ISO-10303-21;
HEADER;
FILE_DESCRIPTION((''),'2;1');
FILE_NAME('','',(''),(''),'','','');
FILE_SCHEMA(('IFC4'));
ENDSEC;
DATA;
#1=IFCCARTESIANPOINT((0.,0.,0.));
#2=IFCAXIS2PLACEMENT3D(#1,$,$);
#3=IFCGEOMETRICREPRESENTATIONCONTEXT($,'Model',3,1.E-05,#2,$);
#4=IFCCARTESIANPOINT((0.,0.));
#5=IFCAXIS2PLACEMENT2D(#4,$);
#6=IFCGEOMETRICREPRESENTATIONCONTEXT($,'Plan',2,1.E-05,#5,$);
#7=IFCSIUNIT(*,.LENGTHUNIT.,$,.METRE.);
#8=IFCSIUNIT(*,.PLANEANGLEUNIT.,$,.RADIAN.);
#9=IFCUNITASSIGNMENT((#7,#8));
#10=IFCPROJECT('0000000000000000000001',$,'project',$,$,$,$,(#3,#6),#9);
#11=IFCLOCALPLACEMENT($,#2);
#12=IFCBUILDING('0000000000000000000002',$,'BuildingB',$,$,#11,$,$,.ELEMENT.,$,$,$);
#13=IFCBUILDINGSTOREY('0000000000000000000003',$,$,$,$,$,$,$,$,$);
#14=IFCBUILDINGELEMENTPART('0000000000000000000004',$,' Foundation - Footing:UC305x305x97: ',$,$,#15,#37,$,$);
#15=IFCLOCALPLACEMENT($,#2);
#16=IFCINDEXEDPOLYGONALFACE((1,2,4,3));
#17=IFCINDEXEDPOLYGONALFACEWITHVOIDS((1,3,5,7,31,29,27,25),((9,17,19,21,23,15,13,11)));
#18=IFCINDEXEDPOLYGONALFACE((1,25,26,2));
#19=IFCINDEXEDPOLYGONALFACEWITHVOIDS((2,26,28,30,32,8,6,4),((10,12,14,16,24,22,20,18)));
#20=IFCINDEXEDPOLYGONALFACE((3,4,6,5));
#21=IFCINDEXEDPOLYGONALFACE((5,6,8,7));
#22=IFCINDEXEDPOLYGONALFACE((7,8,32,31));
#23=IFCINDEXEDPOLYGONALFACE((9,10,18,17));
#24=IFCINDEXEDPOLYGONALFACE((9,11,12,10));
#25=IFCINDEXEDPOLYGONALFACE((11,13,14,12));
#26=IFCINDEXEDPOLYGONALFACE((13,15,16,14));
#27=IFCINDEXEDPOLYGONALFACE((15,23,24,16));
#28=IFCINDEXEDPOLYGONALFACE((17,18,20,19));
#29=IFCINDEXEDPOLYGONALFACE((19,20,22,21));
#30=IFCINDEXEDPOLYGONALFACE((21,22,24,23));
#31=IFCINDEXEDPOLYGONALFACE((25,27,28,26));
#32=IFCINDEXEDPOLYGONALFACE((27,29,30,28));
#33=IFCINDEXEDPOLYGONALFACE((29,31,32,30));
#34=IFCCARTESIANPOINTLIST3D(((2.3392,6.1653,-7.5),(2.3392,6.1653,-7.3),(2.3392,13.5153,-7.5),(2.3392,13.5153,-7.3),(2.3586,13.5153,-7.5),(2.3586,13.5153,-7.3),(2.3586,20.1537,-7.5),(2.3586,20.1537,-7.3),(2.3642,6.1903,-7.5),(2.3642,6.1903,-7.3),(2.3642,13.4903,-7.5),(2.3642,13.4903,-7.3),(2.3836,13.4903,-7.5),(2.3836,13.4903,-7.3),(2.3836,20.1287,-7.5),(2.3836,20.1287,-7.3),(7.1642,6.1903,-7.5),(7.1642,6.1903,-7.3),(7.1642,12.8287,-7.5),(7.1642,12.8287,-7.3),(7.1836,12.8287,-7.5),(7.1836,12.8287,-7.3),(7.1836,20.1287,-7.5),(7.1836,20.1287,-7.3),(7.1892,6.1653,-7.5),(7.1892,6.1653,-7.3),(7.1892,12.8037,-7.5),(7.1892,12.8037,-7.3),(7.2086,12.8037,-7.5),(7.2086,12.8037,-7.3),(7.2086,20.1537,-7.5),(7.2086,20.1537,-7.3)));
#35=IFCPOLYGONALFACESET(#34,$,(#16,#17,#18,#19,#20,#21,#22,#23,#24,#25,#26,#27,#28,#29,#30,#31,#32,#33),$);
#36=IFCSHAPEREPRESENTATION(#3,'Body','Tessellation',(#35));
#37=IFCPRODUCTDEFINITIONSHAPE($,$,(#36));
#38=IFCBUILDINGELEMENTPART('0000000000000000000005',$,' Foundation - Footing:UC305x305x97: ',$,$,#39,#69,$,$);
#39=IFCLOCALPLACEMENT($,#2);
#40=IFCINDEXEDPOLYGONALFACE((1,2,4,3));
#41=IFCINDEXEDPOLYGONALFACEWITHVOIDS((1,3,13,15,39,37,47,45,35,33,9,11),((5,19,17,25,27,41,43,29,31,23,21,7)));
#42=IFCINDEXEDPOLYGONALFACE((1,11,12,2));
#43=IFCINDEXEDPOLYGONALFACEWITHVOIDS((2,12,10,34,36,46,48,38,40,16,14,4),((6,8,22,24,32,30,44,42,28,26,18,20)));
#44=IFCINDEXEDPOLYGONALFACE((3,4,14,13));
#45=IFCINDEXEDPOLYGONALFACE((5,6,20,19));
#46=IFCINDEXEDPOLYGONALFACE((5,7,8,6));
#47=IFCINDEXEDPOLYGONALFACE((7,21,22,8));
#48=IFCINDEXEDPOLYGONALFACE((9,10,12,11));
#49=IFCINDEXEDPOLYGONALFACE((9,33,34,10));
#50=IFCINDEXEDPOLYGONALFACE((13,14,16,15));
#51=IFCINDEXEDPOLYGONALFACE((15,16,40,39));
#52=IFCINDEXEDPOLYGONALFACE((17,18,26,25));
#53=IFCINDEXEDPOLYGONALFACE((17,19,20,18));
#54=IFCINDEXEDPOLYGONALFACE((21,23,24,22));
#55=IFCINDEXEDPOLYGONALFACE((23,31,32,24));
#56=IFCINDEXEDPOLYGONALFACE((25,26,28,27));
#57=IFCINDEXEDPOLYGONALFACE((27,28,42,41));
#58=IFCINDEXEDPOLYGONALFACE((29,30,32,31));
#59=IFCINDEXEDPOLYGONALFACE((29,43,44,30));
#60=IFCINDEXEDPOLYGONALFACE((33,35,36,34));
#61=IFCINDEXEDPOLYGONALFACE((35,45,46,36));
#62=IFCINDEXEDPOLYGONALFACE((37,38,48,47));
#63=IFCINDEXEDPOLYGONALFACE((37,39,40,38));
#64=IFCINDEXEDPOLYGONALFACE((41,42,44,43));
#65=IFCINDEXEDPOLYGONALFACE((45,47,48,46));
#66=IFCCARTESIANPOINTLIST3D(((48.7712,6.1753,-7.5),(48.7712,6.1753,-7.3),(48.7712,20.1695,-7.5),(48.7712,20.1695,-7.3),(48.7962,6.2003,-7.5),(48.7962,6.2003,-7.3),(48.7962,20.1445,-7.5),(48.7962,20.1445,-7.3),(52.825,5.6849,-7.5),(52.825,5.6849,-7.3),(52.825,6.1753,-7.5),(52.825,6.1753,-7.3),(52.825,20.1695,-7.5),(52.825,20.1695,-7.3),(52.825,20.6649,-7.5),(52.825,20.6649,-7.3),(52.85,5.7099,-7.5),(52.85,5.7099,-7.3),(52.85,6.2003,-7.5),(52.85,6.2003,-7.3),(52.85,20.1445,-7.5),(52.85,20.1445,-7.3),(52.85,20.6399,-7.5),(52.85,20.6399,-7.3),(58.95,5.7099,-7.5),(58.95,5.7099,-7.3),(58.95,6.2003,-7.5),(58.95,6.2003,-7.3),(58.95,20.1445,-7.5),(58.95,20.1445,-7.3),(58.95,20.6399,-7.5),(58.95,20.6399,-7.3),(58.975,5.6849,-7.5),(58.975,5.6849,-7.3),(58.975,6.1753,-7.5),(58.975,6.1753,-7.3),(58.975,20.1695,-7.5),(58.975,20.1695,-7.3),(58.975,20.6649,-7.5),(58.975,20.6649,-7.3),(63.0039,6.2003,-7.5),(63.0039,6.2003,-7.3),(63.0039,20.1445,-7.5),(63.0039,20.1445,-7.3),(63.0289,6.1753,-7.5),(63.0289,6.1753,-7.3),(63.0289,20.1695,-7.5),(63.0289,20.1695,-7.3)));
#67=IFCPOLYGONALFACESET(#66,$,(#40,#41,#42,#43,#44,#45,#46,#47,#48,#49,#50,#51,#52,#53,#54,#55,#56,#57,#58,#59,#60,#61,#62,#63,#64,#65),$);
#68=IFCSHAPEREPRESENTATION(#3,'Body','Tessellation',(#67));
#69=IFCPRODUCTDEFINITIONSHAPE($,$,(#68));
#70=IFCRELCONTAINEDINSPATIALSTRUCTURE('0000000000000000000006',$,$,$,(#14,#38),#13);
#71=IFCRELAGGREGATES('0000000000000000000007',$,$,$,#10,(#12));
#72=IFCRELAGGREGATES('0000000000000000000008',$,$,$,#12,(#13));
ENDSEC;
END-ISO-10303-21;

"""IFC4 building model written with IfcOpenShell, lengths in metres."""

from ifc_helpers import new_model, si_unit, origin, origin_2d, place, context, project, spatial, polyline, outline, extrude, element, save


model = new_model("IFC4")

# Units and contexts
model_context = context("Model", 3, precision=1e-05, world=origin())
plan_context = context("Plan", 2, precision=1e-05, world=origin_2d())
ifc_project = project(units=[si_unit("LENGTHUNIT", "METRE"), si_unit("PLANEANGLEUNIT", "RADIAN")], contexts=[model_context, plan_context])

# Building, storey
building_placement = place(None, origin())
building = spatial("IfcBuilding", under=ifc_project, at=building_placement, Name="BuildingB", CompositionType="ELEMENT")
storey = spatial("IfcBuildingStorey", under=building)

# Building element parts, openings
building_element_part_1 = element("IfcBuildingElementPart", 1, inside=storey, Name=" Foundation - Footing:UC305x305x97: ", context=model_context, shape_type="SweptSolid", body=[
    extrude(outline(polyline([(7.1892, 12.8037, -7.5), (7.2086, 12.8037, -7.5), (7.2086, 15.1899, -7.5), (7.2086, 20.1537, -7.5), (2.3586, 20.1537, -7.5), (2.3586, 17.04, -7.5), (2.3586, 13.5153, -7.5), (2.3392, 13.5153, -7.5), (2.3392, 9.16, -7.5), (2.3392, 6.1653, -7.5), (5.3245, 6.1653, -7.5), (7.1892, 6.1653, -7.5), (7.1892, 9.3099, -7.5), (7.1892, 12.8037, -7.5)])), None, (0.0, 0.0, 1.0), 0.2),
])
element("IfcOpeningElement", 2, inside=storey, cuts=building_element_part_1, context=model_context, shape_type="SweptSolid", body=[
    extrude(outline(polyline([(7.1642, 12.8287, -7.5), (7.1836, 12.8287, -7.5), (7.1836, 15.1899, -7.5), (7.1836, 20.1287, -7.5), (2.3836, 20.1287, -7.5), (2.3836, 17.04, -7.5), (2.3836, 13.4903, -7.5), (2.3642, 13.4903, -7.5), (2.3642, 9.16, -7.5), (2.3642, 6.1903, -7.5), (5.3245, 6.1903, -7.5), (7.1642, 6.1903, -7.5), (7.1642, 9.3099, -7.5), (7.1642, 12.8287, -7.5)])), None, (0.0, 0.0, 1.0), 0.2),
])
building_element_part_2 = element("IfcBuildingElementPart", 3, inside=storey, Name=" Foundation - Footing:UC305x305x97: ", context=model_context, shape_type="SweptSolid", body=[
    extrude(outline(polyline([(58.975, 5.6849, -7.5), (58.975, 6.1753, -7.5), (63.0289, 6.1753, -7.5), (63.0289, 20.1695, -7.5), (58.975, 20.1695, -7.5), (58.975, 20.6649, -7.5), (56.5291, 20.6649, -7.5), (54.9522, 20.6649, -7.5), (52.825, 20.6649, -7.5), (52.825, 20.1695, -7.5), (48.7712, 20.1695, -7.5), (48.7712, 6.1753, -7.5), (52.825, 6.1753, -7.5), (52.825, 5.6849, -7.5), (58.975, 5.6849, -7.5)])), None, (0.0, 0.0, 1.0), 0.2),
])
element("IfcOpeningElement", 4, inside=storey, cuts=building_element_part_2, context=model_context, shape_type="SweptSolid", body=[
    extrude(outline(polyline([(58.95, 5.7099, -7.5), (58.95, 6.2003, -7.5), (63.0039, 6.2003, -7.5), (63.0039, 20.1445, -7.5), (58.95, 20.1445, -7.5), (58.95, 20.6399, -7.5), (56.5291, 20.6399, -7.5), (54.9522, 20.6399, -7.5), (52.85, 20.6399, -7.5), (52.85, 20.1445, -7.5), (48.7962, 20.1445, -7.5), (48.7962, 6.2003, -7.5), (52.85, 6.2003, -7.5), (52.85, 5.7099, -7.5), (58.95, 5.7099, -7.5)])), None, (0.0, 0.0, 1.0), 0.2),
])

save(model, "model.ifc")
